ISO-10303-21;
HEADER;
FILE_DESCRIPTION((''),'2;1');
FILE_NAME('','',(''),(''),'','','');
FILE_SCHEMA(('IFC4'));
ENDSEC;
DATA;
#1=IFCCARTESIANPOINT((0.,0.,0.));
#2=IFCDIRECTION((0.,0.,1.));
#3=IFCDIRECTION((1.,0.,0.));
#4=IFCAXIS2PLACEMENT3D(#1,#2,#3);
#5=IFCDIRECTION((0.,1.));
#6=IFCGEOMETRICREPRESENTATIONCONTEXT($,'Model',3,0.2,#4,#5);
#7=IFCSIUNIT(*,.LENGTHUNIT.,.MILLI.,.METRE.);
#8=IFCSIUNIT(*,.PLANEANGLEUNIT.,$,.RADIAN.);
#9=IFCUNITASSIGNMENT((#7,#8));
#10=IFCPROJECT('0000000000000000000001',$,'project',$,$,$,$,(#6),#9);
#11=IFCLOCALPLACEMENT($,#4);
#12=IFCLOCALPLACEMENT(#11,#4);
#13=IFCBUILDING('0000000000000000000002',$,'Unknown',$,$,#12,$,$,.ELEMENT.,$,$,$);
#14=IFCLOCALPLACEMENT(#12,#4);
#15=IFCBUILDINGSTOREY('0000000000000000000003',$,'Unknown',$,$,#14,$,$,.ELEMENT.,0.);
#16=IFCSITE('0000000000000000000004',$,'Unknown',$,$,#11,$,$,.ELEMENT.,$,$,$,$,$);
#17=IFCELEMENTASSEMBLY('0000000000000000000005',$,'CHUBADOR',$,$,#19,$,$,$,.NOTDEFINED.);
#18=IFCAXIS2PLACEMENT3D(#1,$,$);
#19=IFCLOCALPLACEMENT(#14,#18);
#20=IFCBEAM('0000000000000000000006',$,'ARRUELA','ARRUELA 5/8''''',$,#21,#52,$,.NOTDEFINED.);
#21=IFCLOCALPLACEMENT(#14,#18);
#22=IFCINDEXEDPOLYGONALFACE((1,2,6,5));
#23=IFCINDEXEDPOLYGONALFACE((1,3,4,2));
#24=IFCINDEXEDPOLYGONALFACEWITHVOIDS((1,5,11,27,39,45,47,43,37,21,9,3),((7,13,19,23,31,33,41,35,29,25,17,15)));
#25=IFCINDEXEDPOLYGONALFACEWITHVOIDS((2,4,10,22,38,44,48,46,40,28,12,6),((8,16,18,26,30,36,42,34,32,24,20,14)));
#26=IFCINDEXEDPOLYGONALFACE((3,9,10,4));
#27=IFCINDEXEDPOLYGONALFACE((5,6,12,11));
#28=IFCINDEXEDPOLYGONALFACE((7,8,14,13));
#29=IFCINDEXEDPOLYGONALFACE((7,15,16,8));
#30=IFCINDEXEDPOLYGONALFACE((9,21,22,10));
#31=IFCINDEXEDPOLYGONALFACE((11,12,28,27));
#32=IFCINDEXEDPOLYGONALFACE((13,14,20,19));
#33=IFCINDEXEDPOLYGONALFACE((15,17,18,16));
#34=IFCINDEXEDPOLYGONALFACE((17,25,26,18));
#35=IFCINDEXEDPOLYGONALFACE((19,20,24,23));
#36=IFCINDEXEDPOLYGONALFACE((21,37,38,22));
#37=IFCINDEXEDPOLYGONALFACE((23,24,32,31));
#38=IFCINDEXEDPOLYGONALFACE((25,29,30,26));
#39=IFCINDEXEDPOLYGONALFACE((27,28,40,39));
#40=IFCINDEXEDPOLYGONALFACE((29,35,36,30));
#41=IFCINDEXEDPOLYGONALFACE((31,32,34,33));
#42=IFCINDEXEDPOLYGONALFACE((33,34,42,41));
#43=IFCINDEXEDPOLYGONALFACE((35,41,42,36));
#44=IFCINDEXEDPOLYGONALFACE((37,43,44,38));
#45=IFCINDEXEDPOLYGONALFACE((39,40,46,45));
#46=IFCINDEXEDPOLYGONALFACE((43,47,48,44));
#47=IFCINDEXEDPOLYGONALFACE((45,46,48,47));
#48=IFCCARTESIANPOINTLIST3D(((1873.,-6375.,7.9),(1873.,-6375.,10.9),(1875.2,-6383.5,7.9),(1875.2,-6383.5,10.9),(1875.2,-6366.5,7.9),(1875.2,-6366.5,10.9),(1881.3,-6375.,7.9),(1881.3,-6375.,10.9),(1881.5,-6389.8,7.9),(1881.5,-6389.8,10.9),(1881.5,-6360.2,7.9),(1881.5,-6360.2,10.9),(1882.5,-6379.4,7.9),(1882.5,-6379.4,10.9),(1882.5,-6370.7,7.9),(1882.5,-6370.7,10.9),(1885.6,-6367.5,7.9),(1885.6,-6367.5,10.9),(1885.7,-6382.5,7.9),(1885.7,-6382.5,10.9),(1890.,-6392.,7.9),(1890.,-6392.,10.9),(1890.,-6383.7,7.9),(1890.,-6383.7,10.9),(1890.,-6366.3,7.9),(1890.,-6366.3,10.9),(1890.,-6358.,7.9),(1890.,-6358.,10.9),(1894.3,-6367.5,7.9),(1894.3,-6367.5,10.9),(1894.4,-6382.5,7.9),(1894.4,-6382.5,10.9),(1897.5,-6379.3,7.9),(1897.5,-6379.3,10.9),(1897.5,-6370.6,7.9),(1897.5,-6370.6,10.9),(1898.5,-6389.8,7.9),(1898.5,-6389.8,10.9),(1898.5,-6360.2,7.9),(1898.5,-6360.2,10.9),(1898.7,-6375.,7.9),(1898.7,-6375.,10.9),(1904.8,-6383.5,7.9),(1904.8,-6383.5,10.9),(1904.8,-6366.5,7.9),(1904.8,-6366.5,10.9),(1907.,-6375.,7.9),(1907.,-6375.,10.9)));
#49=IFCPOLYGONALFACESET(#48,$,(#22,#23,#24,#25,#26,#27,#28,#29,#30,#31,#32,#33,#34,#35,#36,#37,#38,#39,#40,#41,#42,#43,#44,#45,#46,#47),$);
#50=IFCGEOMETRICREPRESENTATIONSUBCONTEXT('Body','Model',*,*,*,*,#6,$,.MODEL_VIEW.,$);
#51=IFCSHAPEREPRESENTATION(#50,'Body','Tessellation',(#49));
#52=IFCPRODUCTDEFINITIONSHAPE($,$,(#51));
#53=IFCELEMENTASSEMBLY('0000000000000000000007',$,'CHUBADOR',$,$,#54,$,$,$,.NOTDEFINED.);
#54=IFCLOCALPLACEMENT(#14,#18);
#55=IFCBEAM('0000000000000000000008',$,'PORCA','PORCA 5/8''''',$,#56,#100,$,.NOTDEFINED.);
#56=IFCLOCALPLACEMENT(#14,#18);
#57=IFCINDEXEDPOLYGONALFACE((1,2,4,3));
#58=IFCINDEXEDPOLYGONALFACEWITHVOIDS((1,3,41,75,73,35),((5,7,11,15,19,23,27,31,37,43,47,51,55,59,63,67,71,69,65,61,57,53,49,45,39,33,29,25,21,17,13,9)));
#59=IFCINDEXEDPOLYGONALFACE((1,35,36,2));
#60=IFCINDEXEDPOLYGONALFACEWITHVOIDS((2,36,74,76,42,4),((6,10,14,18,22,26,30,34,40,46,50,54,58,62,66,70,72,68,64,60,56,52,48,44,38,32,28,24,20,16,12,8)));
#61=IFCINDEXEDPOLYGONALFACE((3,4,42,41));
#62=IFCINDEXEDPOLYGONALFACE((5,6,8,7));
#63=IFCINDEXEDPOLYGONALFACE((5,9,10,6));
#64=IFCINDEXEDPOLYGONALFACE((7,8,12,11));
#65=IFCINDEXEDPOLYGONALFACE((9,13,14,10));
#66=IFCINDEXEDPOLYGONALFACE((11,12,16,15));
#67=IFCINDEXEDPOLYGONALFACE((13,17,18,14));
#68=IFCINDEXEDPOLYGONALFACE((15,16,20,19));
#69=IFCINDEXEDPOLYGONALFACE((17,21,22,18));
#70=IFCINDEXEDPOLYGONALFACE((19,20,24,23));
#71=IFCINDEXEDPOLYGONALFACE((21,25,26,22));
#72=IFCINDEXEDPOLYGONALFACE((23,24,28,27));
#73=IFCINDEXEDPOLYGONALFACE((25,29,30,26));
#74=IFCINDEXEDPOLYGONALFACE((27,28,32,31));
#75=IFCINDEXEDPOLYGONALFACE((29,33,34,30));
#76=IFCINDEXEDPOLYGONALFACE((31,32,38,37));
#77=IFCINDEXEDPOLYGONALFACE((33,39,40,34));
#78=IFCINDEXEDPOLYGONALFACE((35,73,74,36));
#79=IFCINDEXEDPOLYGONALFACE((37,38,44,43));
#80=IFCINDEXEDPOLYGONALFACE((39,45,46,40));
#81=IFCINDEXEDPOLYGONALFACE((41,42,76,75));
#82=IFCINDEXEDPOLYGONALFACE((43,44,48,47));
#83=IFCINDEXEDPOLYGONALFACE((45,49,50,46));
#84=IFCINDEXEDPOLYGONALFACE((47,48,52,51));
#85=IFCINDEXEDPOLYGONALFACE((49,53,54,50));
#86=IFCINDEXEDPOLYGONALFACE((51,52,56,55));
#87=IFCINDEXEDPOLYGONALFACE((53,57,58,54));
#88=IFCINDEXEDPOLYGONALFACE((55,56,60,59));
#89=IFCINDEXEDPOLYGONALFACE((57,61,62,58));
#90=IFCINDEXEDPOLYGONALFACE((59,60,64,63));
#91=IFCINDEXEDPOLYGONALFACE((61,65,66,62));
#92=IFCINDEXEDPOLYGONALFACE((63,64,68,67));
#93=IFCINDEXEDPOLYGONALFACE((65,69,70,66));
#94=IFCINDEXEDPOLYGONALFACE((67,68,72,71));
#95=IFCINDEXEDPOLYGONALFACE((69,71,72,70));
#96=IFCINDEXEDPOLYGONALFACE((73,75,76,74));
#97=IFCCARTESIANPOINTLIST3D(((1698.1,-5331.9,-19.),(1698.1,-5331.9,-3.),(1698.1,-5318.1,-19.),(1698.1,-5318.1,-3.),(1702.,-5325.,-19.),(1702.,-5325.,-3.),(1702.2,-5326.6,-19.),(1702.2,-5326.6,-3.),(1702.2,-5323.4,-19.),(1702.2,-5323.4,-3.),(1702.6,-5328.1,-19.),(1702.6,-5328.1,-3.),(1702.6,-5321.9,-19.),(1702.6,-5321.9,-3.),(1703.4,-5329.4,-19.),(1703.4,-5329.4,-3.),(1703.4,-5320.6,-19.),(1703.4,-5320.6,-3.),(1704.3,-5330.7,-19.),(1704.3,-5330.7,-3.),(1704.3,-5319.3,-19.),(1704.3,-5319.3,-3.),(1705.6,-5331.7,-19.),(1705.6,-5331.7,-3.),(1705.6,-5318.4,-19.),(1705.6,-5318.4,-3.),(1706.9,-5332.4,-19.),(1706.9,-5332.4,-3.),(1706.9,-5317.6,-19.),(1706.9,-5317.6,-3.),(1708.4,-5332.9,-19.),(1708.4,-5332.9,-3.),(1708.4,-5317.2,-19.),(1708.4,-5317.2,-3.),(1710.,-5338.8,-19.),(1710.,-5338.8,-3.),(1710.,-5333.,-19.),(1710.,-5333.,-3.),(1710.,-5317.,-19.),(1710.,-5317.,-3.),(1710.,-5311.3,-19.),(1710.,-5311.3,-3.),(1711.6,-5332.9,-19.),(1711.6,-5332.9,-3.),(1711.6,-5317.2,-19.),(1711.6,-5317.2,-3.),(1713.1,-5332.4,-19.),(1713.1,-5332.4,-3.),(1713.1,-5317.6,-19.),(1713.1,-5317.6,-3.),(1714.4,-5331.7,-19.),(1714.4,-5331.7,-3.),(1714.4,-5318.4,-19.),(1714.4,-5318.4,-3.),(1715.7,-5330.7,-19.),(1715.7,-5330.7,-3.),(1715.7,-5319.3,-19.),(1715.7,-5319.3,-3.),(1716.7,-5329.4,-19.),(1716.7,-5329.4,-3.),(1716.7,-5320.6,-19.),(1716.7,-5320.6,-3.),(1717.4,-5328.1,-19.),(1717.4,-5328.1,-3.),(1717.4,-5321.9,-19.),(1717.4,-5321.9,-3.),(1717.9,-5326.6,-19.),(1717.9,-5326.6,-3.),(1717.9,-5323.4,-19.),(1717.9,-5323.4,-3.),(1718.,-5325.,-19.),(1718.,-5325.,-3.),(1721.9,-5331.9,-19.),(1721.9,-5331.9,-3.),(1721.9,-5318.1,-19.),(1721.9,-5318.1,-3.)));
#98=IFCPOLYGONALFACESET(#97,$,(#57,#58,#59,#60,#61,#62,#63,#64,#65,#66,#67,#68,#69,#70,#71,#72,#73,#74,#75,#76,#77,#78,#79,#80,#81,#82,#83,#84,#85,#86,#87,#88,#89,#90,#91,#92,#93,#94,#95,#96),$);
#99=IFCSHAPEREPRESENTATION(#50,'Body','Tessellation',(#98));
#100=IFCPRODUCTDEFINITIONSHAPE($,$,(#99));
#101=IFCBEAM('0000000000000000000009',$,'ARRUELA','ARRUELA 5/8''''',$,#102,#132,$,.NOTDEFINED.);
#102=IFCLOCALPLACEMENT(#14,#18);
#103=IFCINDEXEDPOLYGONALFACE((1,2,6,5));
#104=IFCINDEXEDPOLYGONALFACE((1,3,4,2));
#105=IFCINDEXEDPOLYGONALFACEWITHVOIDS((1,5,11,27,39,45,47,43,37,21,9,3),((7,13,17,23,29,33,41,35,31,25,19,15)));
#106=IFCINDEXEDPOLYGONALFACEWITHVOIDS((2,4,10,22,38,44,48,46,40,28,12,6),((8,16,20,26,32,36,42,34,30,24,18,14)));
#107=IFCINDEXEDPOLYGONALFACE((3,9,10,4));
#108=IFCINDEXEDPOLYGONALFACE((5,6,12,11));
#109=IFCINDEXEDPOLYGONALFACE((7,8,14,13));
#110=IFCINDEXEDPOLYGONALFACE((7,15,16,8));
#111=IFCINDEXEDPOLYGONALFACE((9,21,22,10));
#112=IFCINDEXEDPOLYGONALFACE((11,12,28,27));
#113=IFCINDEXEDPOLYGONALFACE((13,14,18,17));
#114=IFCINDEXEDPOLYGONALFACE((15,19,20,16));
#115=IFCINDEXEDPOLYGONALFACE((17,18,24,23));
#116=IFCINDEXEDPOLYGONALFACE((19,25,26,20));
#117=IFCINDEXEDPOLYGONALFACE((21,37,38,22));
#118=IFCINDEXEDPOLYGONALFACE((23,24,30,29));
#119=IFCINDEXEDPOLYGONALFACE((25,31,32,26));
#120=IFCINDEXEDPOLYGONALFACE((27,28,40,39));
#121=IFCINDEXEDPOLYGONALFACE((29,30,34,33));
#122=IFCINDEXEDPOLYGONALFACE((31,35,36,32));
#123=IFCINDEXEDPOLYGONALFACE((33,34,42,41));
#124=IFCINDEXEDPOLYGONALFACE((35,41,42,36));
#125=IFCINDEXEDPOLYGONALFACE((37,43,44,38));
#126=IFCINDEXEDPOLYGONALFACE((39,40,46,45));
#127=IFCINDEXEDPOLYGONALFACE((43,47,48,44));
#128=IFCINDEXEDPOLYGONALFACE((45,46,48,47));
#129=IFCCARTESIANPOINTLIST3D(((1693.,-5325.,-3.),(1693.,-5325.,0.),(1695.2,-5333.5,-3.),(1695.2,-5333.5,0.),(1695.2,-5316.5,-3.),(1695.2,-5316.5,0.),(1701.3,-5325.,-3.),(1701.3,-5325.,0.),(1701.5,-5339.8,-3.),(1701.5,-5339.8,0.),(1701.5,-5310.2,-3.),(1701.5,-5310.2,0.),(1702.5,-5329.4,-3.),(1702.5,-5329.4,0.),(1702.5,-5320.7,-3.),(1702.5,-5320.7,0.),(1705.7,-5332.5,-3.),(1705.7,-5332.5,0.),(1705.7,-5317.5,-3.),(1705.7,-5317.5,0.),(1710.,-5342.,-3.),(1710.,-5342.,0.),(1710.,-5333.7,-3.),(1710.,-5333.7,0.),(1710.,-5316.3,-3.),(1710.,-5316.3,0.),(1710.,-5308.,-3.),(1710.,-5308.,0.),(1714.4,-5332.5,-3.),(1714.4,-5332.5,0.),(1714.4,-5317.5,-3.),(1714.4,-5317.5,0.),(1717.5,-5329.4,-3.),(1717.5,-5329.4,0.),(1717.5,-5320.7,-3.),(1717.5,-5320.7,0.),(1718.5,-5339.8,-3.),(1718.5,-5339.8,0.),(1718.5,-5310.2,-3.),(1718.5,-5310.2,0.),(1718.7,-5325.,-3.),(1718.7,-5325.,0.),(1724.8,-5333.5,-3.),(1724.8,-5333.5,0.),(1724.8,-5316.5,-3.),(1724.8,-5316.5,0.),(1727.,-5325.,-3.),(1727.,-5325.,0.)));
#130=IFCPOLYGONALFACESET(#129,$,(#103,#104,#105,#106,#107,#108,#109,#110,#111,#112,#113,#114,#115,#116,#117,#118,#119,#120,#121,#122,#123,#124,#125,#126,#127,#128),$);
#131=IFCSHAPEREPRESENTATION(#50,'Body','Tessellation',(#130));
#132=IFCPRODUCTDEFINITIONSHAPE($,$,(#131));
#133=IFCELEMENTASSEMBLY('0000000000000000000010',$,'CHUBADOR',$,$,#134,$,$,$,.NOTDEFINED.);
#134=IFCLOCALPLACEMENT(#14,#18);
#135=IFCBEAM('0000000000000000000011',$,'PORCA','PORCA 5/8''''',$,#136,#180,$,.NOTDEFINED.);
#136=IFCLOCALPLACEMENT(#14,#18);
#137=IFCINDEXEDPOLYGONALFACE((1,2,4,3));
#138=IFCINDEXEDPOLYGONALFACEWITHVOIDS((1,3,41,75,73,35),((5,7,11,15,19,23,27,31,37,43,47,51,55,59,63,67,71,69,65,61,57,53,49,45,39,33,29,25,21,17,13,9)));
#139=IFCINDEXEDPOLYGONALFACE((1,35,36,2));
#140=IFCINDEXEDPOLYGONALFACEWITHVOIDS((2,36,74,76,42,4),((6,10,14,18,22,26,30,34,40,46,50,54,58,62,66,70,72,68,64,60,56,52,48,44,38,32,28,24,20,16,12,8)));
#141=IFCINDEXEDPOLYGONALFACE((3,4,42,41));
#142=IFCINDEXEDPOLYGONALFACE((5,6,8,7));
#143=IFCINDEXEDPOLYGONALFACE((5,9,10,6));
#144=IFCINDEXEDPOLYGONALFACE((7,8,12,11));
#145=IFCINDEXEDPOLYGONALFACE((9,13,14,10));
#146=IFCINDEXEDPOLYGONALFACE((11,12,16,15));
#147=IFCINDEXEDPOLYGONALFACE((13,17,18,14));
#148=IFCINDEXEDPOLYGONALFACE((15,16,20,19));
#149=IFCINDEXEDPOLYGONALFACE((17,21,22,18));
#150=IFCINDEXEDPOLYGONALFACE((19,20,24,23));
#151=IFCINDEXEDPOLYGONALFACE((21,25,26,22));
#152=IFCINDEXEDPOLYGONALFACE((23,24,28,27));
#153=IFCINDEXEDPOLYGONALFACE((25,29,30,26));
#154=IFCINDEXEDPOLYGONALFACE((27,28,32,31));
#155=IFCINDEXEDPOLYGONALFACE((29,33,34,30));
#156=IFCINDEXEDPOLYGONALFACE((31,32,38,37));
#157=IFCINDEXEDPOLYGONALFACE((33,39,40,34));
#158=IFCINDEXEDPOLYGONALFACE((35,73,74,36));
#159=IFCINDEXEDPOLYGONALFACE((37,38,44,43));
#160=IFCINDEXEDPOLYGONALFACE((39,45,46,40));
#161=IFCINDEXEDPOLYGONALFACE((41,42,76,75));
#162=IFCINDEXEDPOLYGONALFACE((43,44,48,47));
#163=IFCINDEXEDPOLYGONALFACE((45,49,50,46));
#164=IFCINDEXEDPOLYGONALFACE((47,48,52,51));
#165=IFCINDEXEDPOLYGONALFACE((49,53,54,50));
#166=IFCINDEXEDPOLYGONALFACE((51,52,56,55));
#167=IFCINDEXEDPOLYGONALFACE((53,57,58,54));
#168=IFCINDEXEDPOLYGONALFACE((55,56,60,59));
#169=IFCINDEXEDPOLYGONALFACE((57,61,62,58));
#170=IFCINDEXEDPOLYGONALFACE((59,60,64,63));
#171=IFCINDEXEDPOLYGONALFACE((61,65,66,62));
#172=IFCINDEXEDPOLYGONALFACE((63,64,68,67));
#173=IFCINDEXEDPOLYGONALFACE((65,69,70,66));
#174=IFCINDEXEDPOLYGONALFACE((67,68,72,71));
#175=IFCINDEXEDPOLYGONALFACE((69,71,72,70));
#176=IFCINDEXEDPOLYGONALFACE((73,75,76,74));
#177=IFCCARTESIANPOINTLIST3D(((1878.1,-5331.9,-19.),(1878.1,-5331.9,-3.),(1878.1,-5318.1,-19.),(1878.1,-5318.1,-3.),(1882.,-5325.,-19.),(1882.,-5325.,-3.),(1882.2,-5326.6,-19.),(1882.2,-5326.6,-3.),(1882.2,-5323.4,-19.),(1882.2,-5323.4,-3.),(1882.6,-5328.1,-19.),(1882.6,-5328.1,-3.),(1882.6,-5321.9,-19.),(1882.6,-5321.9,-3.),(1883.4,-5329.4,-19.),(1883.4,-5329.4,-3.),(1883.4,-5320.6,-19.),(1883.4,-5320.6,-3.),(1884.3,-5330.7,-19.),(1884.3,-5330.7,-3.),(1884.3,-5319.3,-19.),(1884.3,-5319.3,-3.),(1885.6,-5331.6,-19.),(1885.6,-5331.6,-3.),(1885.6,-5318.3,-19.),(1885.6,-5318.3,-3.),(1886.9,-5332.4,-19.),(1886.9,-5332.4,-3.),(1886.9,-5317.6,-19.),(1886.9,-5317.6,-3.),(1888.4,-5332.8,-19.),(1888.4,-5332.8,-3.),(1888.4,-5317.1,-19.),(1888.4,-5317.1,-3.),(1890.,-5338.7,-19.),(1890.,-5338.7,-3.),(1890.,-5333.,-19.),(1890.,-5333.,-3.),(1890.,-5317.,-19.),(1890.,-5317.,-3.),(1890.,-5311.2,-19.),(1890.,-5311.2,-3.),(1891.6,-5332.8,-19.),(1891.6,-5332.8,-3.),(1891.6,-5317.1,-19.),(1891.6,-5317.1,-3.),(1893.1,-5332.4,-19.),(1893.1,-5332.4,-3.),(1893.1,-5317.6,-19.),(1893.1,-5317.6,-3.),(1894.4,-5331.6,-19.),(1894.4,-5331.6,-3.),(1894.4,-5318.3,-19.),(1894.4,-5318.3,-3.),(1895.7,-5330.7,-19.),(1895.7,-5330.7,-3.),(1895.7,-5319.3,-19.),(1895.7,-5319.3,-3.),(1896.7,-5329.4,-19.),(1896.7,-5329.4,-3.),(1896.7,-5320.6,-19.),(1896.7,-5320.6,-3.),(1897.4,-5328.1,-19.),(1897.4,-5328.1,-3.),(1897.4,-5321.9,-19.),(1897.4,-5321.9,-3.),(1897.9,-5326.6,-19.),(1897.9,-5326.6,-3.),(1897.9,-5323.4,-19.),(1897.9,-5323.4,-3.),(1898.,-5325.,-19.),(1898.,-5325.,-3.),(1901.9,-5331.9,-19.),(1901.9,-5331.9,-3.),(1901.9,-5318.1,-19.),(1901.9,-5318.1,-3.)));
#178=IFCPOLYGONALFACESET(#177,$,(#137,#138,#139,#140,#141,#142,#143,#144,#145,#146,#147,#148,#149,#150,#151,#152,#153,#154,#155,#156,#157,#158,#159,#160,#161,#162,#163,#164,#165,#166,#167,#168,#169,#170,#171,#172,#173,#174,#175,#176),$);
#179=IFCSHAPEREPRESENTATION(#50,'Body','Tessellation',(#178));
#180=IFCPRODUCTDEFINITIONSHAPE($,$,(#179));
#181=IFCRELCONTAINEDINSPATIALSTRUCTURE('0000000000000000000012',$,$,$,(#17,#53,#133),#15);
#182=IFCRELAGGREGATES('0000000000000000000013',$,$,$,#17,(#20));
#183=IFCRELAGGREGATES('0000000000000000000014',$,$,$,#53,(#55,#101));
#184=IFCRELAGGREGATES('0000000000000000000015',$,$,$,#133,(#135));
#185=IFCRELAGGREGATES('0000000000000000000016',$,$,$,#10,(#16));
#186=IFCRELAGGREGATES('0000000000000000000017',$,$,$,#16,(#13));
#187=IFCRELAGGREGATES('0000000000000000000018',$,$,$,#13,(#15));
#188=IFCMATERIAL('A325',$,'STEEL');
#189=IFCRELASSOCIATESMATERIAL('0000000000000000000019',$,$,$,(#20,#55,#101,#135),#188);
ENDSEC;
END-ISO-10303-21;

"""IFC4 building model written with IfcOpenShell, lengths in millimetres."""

from ifc_helpers import new_model, si_unit, direction, frame, origin_with_axes, place, context, subcontext, project, spatial, line, indexed_curve, outline, extrude, material, element, aggregate, save


model = new_model("IFC4")

# Units and contexts
model_context = context("Model", 3, precision=0.2, world=origin_with_axes(), true_north=direction((0.0, 1.0)))
body_context = subcontext(model_context, "Body", "Model", "MODEL_VIEW")
ifc_project = project(units=[si_unit("LENGTHUNIT", "METRE", prefix="MILLI"), si_unit("PLANEANGLEUNIT", "RADIAN")], contexts=[model_context])

# Site, building, storey
site_placement = place(None, origin_with_axes())
site = spatial("IfcSite", under=ifc_project, at=site_placement, Name="Unknown", CompositionType="ELEMENT")
building_placement = place(site_placement, origin_with_axes())
building = spatial("IfcBuilding", under=site, at=building_placement, Name="Unknown", CompositionType="ELEMENT")
storey_placement = place(building_placement, origin_with_axes())
storey = spatial("IfcBuildingStorey", under=building, at=storey_placement, Name="Unknown", CompositionType="ELEMENT", Elevation=0.0)

# Shared definitions
ifc_material_1 = material(Name="A325", Category="STEEL")

# Element assemblies, beams
assembly_1_placement = place(storey_placement, frame((1890.0, -6375.0, -52.1), z_axis=(1.0, 0.0, 0.0), x_axis=(0.0, 0.0, -1.0)))
assembly_1 = element("IfcElementAssembly", 1, at=assembly_1_placement, inside=storey, Name="CHUBADOR", PredefinedType="NOTDEFINED")
beam_1_placement = place(assembly_1_placement, frame((-63.0, 0.0, 0.0), z_axis=(0.0, 0.0, 1.0), x_axis=(1.0, 0.0, 0.0)))
beam_1 = element("IfcBeam", 2, at=beam_1_placement, material=ifc_material_1, Name="ARRUELA", Description="ARRUELA 5/8''", PredefinedType="NOTDEFINED", context=body_context, shape_type="SolidModel", body=[
    extrude(outline(indexed_curve([(17.0, 0.0), (14.8, 8.5), (8.5, 14.8), (0.0, 17.0), (-8.5, 14.8), (-14.8, 8.5), (-17.0, 0.0), (-14.8, -8.5), (-8.5, -14.8), (0.0, -17.0), (8.5, -14.8), (14.8, -8.5)], segments=[line(1, 2, 3, 4, 5, 6, 7, 8, 9, 10, 11, 12, 1)]), holes=[indexed_curve([(8.7, 0.0), (7.5, -4.3), (4.3, -7.5), (0.0, -8.7), (-4.3, -7.5), (-7.5, -4.3), (-8.7, 0.0), (-7.5, 4.3), (-4.3, 7.5), (0.0, 8.7), (4.3, 7.5), (7.5, 4.3)], segments=[line(1, 2, 3, 4, 5, 6, 7, 8, 9, 10, 11, 12, 1)])]), frame((0.0, 0.0, 0.0), z_axis=(-1.0, 0.0, 0.0), x_axis=(0.0, 0.0, 1.0)), (0.0, 0.0, -1.0), 3.0),
])
aggregate(assembly_1, [beam_1])
assembly_2_placement = place(storey_placement, frame((1710.0, -5325.0, -52.1), z_axis=(-1.0, 0.0, 0.0), x_axis=(0.0, 0.0, -1.0)))
assembly_2 = element("IfcElementAssembly", 3, at=assembly_2_placement, inside=storey, Name="CHUBADOR", PredefinedType="NOTDEFINED")
beam_2_placement = place(assembly_2_placement, frame((-49.1, 0.0, 0.0), z_axis=(0.0, 0.0, 1.0), x_axis=(1.0, 0.0, 0.0)))
beam_2 = element("IfcBeam", 4, at=beam_2_placement, material=ifc_material_1, Name="PORCA", Description="PORCA 5/8''", PredefinedType="NOTDEFINED", context=body_context, shape_type="SolidModel", body=[
    extrude(outline(indexed_curve([(0.0, 13.8), (-11.9, 6.9), (-11.9, -6.9), (0.0, -13.8), (11.9, -6.9), (11.9, 6.9)], segments=[line(1, 2, 3, 4, 5, 6, 1)]), holes=[indexed_curve([(7.8, 1.6), (8.0, 0.0), (7.8, -1.6), (7.4, -3.1), (6.7, -4.4), (5.7, -5.7), (4.4, -6.7), (3.1, -7.4), (1.6, -7.8), (0.0, -8.0), (-1.6, -7.8), (-3.1, -7.4), (-4.4, -6.7), (-5.7, -5.7), (-6.7, -4.4), (-7.4, -3.1), (-7.8, -1.6), (-8.0, 0.0), (-7.8, 1.6), (-7.4, 3.1), (-6.7, 4.4), (-5.7, 5.7), (-4.4, 6.7), (-3.1, 7.4), (-1.6, 7.8), (0.0, 8.0), (1.6, 7.8), (3.1, 7.4), (4.4, 6.7), (5.7, 5.7), (6.7, 4.4), (7.4, 3.1)], segments=[line(1, 2, 3, 4, 5, 6, 7, 8, 9, 10, 11, 12, 13, 14, 15, 16, 17, 18, 19, 20, 21, 22, 23, 24, 25, 26, 27, 28, 29, 30, 31, 32, 1)])]), frame((0.0, 0.0, 0.0), z_axis=(-1.0, 0.0, 0.0), x_axis=(0.0, 0.0, 1.0)), (0.0, 0.0, -1.0), 16.0),
])
beam_3_placement = place(assembly_2_placement, frame((-52.1, 0.0, 0.0), z_axis=(0.0, 0.0, 1.0), x_axis=(1.0, 0.0, 0.0)))
beam_3 = element("IfcBeam", 5, at=beam_3_placement, material=ifc_material_1, Name="ARRUELA", Description="ARRUELA 5/8''", PredefinedType="NOTDEFINED", context=body_context, shape_type="SolidModel", body=[
    extrude(outline(indexed_curve([(17.0, 0.0), (14.8, 8.5), (8.5, 14.8), (0.0, 17.0), (-8.5, 14.8), (-14.8, 8.5), (-17.0, 0.0), (-14.8, -8.5), (-8.5, -14.8), (0.0, -17.0), (8.5, -14.8), (14.8, -8.5)], segments=[line(1, 2, 3, 4, 5, 6, 7, 8, 9, 10, 11, 12, 1)]), holes=[indexed_curve([(8.7, 0.0), (7.5, -4.3), (4.3, -7.5), (0.0, -8.7), (-4.3, -7.5), (-7.5, -4.3), (-8.7, 0.0), (-7.5, 4.3), (-4.3, 7.5), (0.0, 8.7), (4.3, 7.5), (7.5, 4.3)], segments=[line(1, 2, 3, 4, 5, 6, 7, 8, 9, 10, 11, 12, 1)])]), frame((0.0, 0.0, 0.0), z_axis=(-1.0, 0.0, 0.0), x_axis=(0.0, 0.0, 1.0)), (0.0, 0.0, -1.0), 3.0),
])
aggregate(assembly_2, [beam_2, beam_3])
assembly_3_placement = place(storey_placement, frame((1890.0, -5325.0, -52.1), z_axis=(1.0, 0.0, 0.0), x_axis=(0.0, 0.0, -1.0)))
assembly_3 = element("IfcElementAssembly", 6, at=assembly_3_placement, inside=storey, Name="CHUBADOR", PredefinedType="NOTDEFINED")
beam_4_placement = place(assembly_3_placement, frame((-49.1, 0.0, 0.0), z_axis=(0.0, 0.0, 1.0), x_axis=(1.0, 0.0, 0.0)))
beam_4 = element("IfcBeam", 7, at=beam_4_placement, material=ifc_material_1, Name="PORCA", Description="PORCA 5/8''", PredefinedType="NOTDEFINED", context=body_context, shape_type="SolidModel", body=[
    extrude(outline(indexed_curve([(0.0, 13.8), (-11.9, 6.9), (-11.9, -6.9), (0.0, -13.8), (11.9, -6.9), (11.9, 6.9)], segments=[line(1, 2, 3, 4, 5, 6, 1)]), holes=[indexed_curve([(7.8, 1.6), (8.0, 0.0), (7.8, -1.6), (7.4, -3.1), (6.7, -4.4), (5.7, -5.7), (4.4, -6.7), (3.1, -7.4), (1.6, -7.8), (0.0, -8.0), (-1.6, -7.8), (-3.1, -7.4), (-4.4, -6.7), (-5.7, -5.7), (-6.7, -4.4), (-7.4, -3.1), (-7.8, -1.6), (-8.0, 0.0), (-7.8, 1.6), (-7.4, 3.1), (-6.7, 4.4), (-5.7, 5.7), (-4.4, 6.7), (-3.1, 7.4), (-1.6, 7.8), (0.0, 8.0), (1.6, 7.8), (3.1, 7.4), (4.4, 6.7), (5.7, 5.7), (6.7, 4.4), (7.4, 3.1)], segments=[line(1, 2, 3, 4, 5, 6, 7, 8, 9, 10, 11, 12, 13, 14, 15, 16, 17, 18, 19, 20, 21, 22, 23, 24, 25, 26, 27, 28, 29, 30, 31, 32, 1)])]), frame((0.0, 0.0, 0.0), z_axis=(-1.0, 0.0, 0.0), x_axis=(0.0, 0.0, 1.0)), (0.0, 0.0, -1.0), 16.0),
])
aggregate(assembly_3, [beam_4])

save(model, "model.ifc")
